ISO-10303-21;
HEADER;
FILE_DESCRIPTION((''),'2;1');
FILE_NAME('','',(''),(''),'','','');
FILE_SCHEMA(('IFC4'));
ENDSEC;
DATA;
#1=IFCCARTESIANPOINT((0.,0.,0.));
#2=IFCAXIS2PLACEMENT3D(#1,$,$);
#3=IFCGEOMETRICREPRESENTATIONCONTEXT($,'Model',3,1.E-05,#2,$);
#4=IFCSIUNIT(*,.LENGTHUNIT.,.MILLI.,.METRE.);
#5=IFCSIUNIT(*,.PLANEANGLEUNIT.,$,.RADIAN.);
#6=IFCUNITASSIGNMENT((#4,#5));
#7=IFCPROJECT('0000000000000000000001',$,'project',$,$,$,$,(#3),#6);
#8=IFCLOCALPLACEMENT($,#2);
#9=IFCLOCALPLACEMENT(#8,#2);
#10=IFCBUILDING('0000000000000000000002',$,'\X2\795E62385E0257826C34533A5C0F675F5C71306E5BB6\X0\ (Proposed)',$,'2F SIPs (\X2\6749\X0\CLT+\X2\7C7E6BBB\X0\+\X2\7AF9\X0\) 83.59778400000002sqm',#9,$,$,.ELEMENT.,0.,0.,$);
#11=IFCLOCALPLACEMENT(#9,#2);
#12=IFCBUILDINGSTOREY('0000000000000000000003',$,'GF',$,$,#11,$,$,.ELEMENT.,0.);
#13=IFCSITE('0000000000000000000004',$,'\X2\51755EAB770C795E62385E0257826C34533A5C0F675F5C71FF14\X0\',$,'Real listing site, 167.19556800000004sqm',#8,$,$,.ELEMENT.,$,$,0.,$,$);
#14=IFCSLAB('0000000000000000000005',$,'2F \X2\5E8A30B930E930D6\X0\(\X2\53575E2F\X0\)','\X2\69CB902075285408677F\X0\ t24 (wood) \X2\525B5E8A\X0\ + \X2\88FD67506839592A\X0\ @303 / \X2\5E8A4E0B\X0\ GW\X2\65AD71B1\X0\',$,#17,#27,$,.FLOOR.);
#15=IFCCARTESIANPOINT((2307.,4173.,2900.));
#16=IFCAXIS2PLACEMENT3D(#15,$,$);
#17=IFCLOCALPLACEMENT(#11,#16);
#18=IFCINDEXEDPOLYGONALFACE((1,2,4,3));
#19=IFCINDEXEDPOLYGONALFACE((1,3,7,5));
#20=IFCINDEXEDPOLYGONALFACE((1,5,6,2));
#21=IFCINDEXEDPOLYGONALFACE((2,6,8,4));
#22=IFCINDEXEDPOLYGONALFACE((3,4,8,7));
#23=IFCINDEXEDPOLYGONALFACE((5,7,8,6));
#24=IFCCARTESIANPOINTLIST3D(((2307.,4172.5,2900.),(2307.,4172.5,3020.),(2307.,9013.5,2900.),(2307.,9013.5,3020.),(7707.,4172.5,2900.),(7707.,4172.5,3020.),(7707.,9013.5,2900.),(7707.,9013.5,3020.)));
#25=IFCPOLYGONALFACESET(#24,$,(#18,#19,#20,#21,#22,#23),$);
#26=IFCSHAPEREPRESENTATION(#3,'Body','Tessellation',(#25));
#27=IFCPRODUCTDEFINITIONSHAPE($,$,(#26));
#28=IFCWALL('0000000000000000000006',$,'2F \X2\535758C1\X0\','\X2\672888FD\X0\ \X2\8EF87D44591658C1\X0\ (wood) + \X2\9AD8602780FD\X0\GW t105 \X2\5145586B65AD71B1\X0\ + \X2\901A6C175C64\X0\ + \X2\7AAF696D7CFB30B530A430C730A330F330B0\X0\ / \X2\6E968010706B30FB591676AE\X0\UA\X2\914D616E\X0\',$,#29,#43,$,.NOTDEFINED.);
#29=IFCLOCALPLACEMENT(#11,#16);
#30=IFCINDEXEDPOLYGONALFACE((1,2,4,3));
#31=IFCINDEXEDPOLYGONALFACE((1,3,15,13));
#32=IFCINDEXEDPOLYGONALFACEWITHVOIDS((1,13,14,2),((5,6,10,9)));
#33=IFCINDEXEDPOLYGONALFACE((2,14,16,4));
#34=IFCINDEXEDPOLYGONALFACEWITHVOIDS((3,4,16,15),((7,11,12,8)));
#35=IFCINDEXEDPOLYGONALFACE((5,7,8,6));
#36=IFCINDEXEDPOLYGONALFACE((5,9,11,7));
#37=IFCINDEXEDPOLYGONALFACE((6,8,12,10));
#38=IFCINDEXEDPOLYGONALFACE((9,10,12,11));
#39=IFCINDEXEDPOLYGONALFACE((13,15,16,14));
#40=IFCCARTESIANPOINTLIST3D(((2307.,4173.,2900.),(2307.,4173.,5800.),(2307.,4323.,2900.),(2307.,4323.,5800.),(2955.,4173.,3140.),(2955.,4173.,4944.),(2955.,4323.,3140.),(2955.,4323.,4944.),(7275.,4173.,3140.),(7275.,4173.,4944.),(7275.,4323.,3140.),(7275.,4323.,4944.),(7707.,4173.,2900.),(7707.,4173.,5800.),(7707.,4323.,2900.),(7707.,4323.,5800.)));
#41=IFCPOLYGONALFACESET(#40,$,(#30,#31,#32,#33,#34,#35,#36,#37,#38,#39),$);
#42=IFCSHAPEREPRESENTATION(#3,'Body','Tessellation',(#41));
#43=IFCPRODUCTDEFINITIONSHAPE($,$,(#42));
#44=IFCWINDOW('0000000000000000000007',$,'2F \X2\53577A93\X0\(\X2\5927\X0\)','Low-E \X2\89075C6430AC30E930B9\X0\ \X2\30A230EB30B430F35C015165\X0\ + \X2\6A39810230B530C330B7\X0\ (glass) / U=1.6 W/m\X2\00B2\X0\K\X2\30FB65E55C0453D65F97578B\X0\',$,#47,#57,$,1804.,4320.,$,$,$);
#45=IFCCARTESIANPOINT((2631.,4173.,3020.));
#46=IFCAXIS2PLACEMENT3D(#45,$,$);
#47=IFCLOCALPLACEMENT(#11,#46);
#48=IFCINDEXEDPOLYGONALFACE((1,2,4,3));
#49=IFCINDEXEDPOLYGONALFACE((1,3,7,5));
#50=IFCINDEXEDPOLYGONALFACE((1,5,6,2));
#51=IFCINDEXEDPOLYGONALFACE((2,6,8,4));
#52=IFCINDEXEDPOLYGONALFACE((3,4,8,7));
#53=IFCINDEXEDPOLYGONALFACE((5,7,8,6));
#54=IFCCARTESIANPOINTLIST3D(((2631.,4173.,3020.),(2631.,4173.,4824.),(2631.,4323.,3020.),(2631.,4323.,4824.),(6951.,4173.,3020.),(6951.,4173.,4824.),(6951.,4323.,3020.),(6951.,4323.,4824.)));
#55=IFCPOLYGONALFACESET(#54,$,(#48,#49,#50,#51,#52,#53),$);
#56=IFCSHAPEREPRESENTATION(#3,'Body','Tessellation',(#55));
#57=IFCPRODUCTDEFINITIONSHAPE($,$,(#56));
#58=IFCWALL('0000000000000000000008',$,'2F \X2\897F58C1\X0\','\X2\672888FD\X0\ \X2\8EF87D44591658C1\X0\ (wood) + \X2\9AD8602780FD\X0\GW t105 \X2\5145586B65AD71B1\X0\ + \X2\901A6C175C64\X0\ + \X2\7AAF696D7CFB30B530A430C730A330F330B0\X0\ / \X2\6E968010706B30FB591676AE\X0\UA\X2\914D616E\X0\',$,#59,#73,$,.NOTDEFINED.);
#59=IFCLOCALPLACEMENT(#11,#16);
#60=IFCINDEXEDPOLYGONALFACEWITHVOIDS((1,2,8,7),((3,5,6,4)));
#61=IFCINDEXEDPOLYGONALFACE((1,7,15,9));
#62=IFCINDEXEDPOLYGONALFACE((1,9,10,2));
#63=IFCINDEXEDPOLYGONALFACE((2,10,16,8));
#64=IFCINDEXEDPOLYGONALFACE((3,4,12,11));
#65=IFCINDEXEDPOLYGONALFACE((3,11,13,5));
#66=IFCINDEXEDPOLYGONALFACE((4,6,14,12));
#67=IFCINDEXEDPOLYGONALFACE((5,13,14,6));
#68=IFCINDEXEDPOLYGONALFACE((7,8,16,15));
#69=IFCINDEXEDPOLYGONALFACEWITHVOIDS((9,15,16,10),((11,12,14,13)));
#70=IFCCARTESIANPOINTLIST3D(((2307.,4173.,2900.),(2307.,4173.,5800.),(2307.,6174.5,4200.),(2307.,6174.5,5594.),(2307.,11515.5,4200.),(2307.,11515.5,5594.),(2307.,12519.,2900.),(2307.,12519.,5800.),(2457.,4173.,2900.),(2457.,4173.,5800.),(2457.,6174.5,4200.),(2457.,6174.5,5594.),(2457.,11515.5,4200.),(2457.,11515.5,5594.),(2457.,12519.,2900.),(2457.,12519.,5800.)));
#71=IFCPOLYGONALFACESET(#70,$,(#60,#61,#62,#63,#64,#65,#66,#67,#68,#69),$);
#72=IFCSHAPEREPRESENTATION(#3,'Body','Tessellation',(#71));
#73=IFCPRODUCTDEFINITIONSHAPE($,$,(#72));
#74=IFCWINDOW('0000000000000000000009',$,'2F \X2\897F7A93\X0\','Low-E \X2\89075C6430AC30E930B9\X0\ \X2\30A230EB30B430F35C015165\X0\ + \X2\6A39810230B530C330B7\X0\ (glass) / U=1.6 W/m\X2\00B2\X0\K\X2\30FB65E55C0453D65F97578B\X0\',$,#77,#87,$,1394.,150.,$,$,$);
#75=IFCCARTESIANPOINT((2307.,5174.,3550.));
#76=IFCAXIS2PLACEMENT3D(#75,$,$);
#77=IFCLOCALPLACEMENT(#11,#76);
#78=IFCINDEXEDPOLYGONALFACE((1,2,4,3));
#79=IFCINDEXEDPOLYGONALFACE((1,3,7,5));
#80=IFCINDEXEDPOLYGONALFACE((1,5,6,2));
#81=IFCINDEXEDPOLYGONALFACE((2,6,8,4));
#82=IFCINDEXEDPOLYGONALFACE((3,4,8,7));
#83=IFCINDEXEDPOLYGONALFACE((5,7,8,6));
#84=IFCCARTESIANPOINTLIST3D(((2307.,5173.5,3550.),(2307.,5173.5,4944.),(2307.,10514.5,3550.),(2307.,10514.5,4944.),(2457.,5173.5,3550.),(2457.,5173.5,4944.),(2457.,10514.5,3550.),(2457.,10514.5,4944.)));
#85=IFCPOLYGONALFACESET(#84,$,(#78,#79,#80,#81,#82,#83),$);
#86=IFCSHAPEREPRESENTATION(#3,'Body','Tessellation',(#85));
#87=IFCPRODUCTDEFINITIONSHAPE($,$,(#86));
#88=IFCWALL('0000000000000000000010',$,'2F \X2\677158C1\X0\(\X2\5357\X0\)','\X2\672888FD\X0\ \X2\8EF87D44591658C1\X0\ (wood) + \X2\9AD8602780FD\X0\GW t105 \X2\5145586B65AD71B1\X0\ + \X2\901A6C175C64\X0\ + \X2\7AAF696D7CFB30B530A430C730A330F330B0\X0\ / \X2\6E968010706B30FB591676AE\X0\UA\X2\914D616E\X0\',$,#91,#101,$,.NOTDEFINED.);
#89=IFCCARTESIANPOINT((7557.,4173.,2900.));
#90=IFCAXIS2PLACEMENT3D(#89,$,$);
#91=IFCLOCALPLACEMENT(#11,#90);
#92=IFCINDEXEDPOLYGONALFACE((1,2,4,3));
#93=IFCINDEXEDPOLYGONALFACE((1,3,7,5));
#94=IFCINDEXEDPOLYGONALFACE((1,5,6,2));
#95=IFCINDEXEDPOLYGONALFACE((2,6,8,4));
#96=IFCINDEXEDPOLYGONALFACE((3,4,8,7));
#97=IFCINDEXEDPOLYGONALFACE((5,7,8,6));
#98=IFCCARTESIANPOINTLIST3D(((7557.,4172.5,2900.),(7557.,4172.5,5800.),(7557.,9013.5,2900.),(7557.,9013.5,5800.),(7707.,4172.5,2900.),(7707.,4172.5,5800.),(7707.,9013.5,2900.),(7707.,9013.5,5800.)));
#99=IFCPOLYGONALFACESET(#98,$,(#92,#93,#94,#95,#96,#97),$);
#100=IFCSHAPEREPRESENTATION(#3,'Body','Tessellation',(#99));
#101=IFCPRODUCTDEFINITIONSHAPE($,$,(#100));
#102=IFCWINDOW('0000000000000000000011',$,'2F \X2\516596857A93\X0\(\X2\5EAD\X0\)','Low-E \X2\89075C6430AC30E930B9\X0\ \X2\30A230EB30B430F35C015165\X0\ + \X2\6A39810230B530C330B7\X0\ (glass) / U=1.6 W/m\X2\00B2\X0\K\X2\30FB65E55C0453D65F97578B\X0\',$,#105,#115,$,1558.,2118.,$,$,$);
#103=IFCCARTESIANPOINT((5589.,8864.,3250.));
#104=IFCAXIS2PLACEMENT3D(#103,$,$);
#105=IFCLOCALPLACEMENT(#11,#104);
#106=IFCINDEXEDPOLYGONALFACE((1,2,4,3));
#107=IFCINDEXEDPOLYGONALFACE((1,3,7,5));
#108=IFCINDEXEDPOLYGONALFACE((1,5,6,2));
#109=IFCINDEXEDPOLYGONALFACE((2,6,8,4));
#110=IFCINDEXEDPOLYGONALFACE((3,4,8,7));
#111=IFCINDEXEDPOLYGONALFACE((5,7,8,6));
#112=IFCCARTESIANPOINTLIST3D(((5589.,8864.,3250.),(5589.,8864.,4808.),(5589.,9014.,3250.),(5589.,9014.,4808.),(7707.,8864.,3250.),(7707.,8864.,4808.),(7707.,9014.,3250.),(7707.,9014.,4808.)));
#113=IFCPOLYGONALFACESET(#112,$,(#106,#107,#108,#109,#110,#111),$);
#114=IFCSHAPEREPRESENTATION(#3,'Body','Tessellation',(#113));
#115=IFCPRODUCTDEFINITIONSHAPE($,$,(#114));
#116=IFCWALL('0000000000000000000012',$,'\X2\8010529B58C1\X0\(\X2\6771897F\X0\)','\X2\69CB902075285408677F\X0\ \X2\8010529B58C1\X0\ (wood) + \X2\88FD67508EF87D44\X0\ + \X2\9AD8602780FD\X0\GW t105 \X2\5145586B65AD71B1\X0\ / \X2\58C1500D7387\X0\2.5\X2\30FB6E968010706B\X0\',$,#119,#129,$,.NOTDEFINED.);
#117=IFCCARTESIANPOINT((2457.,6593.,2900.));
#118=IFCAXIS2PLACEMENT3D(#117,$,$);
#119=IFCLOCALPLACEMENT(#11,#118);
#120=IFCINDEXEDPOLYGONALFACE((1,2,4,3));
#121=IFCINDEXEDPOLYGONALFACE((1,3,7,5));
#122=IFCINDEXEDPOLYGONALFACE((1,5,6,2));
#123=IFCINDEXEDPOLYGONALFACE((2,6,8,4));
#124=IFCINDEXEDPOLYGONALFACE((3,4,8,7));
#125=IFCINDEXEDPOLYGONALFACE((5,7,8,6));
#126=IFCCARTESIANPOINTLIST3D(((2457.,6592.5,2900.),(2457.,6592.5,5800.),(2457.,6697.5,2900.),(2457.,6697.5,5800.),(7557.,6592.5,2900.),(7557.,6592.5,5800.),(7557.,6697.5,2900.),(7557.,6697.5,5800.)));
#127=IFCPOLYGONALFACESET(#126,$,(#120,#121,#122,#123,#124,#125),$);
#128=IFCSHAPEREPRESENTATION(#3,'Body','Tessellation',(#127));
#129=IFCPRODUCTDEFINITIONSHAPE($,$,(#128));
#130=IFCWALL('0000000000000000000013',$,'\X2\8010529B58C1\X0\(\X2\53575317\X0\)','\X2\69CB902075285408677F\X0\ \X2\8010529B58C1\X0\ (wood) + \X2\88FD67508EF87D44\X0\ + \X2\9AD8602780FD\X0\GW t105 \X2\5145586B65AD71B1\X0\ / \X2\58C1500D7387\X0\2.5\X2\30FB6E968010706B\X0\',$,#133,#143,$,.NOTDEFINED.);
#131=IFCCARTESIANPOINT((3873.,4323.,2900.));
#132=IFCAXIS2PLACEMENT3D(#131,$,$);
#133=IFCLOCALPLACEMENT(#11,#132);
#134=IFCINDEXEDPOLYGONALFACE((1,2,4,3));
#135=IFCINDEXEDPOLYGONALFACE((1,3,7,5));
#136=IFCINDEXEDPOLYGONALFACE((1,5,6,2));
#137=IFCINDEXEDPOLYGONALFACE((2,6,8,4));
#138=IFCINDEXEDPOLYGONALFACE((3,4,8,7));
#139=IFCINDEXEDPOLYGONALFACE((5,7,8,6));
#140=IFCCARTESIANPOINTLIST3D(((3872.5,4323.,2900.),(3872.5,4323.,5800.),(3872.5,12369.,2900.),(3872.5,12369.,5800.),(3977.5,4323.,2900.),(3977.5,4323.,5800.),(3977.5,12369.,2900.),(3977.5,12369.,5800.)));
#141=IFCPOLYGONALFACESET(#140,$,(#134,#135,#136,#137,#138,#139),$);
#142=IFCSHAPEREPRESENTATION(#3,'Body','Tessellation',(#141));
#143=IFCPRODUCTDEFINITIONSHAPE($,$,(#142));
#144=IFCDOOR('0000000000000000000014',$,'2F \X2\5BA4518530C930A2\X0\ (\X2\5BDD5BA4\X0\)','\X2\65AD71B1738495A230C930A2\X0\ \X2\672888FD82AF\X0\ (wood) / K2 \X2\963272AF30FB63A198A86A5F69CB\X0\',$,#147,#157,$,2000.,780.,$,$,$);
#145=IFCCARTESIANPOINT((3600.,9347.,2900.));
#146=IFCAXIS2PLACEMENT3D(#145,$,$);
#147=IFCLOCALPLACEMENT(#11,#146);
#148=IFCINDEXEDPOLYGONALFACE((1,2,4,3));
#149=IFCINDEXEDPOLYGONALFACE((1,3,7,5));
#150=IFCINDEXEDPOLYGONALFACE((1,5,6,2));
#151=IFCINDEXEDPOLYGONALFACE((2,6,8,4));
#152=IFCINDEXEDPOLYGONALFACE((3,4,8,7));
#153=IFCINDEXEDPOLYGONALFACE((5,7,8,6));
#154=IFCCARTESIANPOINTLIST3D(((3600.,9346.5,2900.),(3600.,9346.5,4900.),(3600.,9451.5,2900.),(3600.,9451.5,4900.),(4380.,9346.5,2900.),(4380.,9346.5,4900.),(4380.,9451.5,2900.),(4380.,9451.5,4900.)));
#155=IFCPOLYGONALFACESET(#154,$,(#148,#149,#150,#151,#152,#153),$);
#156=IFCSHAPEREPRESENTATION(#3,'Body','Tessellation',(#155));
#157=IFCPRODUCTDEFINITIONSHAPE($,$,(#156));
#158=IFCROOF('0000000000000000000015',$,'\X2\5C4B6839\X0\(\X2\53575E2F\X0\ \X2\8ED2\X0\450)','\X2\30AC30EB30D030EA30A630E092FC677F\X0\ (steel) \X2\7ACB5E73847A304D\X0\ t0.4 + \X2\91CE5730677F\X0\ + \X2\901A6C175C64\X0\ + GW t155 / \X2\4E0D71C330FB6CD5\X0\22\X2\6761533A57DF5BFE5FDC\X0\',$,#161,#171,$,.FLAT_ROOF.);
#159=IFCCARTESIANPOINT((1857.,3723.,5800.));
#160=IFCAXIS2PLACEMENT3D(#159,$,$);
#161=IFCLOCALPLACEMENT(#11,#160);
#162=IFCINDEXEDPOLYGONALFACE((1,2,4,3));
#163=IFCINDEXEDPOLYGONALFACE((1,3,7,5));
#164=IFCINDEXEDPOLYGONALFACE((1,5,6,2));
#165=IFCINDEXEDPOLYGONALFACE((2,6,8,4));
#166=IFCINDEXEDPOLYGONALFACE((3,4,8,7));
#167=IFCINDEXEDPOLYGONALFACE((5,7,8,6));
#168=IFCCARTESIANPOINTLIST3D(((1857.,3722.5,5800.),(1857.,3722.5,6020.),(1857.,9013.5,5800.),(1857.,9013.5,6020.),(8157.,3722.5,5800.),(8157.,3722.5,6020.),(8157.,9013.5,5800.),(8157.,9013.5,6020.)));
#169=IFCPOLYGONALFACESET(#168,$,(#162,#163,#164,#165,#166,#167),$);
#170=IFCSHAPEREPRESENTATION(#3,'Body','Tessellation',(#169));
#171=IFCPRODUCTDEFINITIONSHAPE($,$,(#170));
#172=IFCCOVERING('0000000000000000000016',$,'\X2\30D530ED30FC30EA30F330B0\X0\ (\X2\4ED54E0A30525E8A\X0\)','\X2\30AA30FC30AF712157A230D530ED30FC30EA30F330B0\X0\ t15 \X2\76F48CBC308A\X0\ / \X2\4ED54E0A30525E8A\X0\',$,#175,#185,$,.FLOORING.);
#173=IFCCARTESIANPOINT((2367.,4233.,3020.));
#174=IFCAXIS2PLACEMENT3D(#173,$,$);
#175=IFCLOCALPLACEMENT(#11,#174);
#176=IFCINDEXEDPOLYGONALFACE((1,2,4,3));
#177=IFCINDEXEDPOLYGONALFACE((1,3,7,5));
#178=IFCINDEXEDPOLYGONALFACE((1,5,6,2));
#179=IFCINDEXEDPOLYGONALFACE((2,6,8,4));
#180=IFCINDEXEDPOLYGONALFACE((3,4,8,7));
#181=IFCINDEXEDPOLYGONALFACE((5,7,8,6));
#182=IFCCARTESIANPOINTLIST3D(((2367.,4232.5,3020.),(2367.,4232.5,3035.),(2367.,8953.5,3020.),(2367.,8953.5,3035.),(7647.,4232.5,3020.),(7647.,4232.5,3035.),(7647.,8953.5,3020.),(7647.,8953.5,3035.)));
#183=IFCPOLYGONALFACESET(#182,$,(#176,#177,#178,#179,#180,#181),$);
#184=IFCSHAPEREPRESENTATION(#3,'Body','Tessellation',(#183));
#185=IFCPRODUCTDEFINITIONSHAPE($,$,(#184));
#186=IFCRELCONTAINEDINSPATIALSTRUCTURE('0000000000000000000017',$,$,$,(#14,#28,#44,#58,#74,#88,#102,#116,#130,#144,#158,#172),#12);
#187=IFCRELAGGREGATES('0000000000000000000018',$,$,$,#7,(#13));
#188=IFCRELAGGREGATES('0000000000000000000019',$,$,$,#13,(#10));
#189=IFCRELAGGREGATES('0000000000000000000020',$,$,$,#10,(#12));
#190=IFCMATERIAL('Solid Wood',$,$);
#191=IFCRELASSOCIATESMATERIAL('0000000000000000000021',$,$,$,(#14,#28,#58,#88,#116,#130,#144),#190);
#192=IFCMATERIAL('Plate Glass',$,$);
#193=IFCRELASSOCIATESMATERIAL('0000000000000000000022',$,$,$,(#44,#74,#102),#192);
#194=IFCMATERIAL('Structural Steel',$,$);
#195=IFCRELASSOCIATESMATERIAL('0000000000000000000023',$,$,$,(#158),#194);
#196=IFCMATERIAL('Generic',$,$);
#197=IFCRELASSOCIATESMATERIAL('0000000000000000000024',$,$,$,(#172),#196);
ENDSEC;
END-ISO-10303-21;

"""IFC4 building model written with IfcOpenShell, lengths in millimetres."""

from ifc_helpers import new_model, si_unit, frame, frame_2d, origin, place, context, project, spatial, rectangle, extrude, material, element, fill, save


model = new_model("IFC4")

# Units and contexts
model_context = context("Model", 3, precision=1e-05, world=origin())
ifc_project = project(units=[si_unit("LENGTHUNIT", "METRE", prefix="MILLI"), si_unit("PLANEANGLEUNIT", "RADIAN")], contexts=[model_context])

# Site, building, storey
site_placement = place(None, origin())
site = spatial("IfcSite", under=ifc_project, at=site_placement, Name="兵庫県神戸市垂水区小束山４", ObjectType="Real listing site, 167.19556800000004sqm", CompositionType="ELEMENT", RefElevation=0.0)
building_placement = place(site_placement, origin())
building = spatial("IfcBuilding", under=site, at=building_placement, Name="神戸市垂水区小束山の家 (Proposed)", ObjectType="2F SIPs (杉CLT+籾殻+竹) 83.59778400000002sqm", CompositionType="ELEMENT", ElevationOfRefHeight=0.0, ElevationOfTerrain=0.0)
storey_placement = place(building_placement, origin())
storey = spatial("IfcBuildingStorey", under=building, at=storey_placement, Name="GF", CompositionType="ELEMENT", Elevation=0.0)

# Slab
ifc_material_1 = material(Name="Solid Wood")
slab_placement = place(storey_placement, frame((2307.0, 4173.0, 2900.0)))
element("IfcSlab", 1, at=slab_placement, inside=storey, material=ifc_material_1, Name="2F 床スラブ(南帯)", Description="構造用合板 t24 (wood) 剛床 + 製材根太 @303 / 床下 GW断熱", PredefinedType="FLOOR", context=model_context, shape_type="SweptSolid", body=[
    extrude(rectangle(XDim=5400.0, YDim=4841.0, at=frame_2d((2700.0, 2420.0))), frame((2307.0, 4173.0, 2900.0)), (0.0, 0.0, 1.0), 120.0),
])

# Walls, openings, windows
wall_1_placement = place(storey_placement, frame((2307.0, 4173.0, 2900.0)))
wall_1 = element("IfcWall", 2, at=wall_1_placement, inside=storey, material=ifc_material_1, Name="2F 南壁", Description="木製 軸組外壁 (wood) + 高性能GW t105 充填断熱 + 通気層 + 窯業系サイディング / 準耐火・外皮UA配慮", PredefinedType="NOTDEFINED", context=model_context, shape_type="SweptSolid", body=[
    extrude(rectangle(XDim=5400.0, YDim=150.0, at=frame_2d((2700.0, 75.0))), frame((2307.0, 4173.0, 2900.0)), (0.0, 0.0, 1.0), 2900.0),
])
opening_1_placement = place(storey_placement, frame((2631.0, 4173.0, 3020.0)))
opening_1 = element("IfcOpeningElement", 3, at=opening_1_placement, cuts=wall_1, PredefinedType="NOTDEFINED", context=model_context, shape_type="SweptSolid", body=[
    extrude(rectangle(XDim=4320.0, YDim=150.0, at=frame_2d((2160.0, 75.0))), frame((2631.0, 4173.0, 3020.0)), (0.0, 0.0, 1.0), 1804.0),
])
ifc_material_2 = material(Name="Plate Glass")
window_1_placement = place(storey_placement, frame((2631.0, 4173.0, 3020.0)))
window_1 = element("IfcWindow", 4, at=window_1_placement, inside=storey, material=ifc_material_2, Name="2F 南窓(大)", Description="Low-E 複層ガラス アルゴン封入 + 樹脂サッシ (glass) / U=1.6 W/m²K・日射取得型", OverallHeight=1804.0, OverallWidth=4320.0, context=model_context, shape_type="SweptSolid", body=[
    extrude(rectangle(XDim=4320.0, YDim=150.0, at=frame_2d((2160.0, 75.0))), frame((2631.0, 4173.0, 3020.0)), (0.0, 0.0, 1.0), 1804.0),
])
fill(opening_1, window_1)
wall_2_placement = place(storey_placement, frame((2307.0, 4173.0, 2900.0)))
wall_2 = element("IfcWall", 5, at=wall_2_placement, inside=storey, material=ifc_material_1, Name="2F 西壁", Description="木製 軸組外壁 (wood) + 高性能GW t105 充填断熱 + 通気層 + 窯業系サイディング / 準耐火・外皮UA配慮", PredefinedType="NOTDEFINED", context=model_context, shape_type="SweptSolid", body=[
    extrude(rectangle(XDim=150.0, YDim=8346.0, at=frame_2d((75.0, 4173.0))), frame((2307.0, 4173.0, 2900.0)), (0.0, 0.0, 1.0), 2900.0),
])
opening_2_placement = place(storey_placement, frame((2307.0, 5174.0, 3550.0)))
opening_2 = element("IfcOpeningElement", 6, at=opening_2_placement, cuts=wall_2, PredefinedType="NOTDEFINED", context=model_context, shape_type="SweptSolid", body=[
    extrude(rectangle(XDim=150.0, YDim=5341.0, at=frame_2d((75.0, 2670.0))), frame((2307.0, 5174.0, 3550.0)), (0.0, 0.0, 1.0), 1394.0),
])
window_2_placement = place(storey_placement, frame((2307.0, 5174.0, 3550.0)))
window_2 = element("IfcWindow", 7, at=window_2_placement, inside=storey, material=ifc_material_2, Name="2F 西窓", Description="Low-E 複層ガラス アルゴン封入 + 樹脂サッシ (glass) / U=1.6 W/m²K・日射取得型", OverallHeight=1394.0, OverallWidth=150.0, context=model_context, shape_type="SweptSolid", body=[
    extrude(rectangle(XDim=150.0, YDim=5341.0, at=frame_2d((75.0, 2670.0))), frame((2307.0, 5174.0, 3550.0)), (0.0, 0.0, 1.0), 1394.0),
])
fill(opening_2, window_2)
wall_3_placement = place(storey_placement, frame((7557.0, 4173.0, 2900.0)))
wall_3 = element("IfcWall", 8, at=wall_3_placement, inside=storey, material=ifc_material_1, Name="2F 東壁(南)", Description="木製 軸組外壁 (wood) + 高性能GW t105 充填断熱 + 通気層 + 窯業系サイディング / 準耐火・外皮UA配慮", PredefinedType="NOTDEFINED", context=model_context, shape_type="SweptSolid", body=[
    extrude(rectangle(XDim=150.0, YDim=4841.0, at=frame_2d((75.0, 2420.0))), frame((7557.0, 4173.0, 2900.0)), (0.0, 0.0, 1.0), 2900.0),
])
opening_3_placement = place(storey_placement, frame((5589.0, 8864.0, 3250.0)))
opening_3 = element("IfcOpeningElement", 9, at=opening_3_placement, cuts=wall_3, PredefinedType="NOTDEFINED", context=model_context, shape_type="SweptSolid", body=[
    extrude(rectangle(XDim=2118.0, YDim=150.0, at=frame_2d((1059.0, 75.0))), frame((5589.0, 8864.0, 3250.0)), (0.0, 0.0, 1.0), 1558.0),
])
window_3_placement = place(storey_placement, frame((5589.0, 8864.0, 3250.0)))
window_3 = element("IfcWindow", 10, at=window_3_placement, inside=storey, material=ifc_material_2, Name="2F 入隅窓(庭)", Description="Low-E 複層ガラス アルゴン封入 + 樹脂サッシ (glass) / U=1.6 W/m²K・日射取得型", OverallHeight=1558.0, OverallWidth=2118.0, context=model_context, shape_type="SweptSolid", body=[
    extrude(rectangle(XDim=2118.0, YDim=150.0, at=frame_2d((1059.0, 75.0))), frame((5589.0, 8864.0, 3250.0)), (0.0, 0.0, 1.0), 1558.0),
])
fill(opening_3, window_3)

# Wall
wall_4_placement = place(storey_placement, frame((2457.0, 6593.0, 2900.0)))
element("IfcWall", 11, at=wall_4_placement, inside=storey, material=ifc_material_1, Name="耐力壁(東西)", Description="構造用合板 耐力壁 (wood) + 製材軸組 + 高性能GW t105 充填断熱 / 壁倍率2.5・準耐火", PredefinedType="NOTDEFINED", context=model_context, shape_type="SweptSolid", body=[
    extrude(rectangle(XDim=5100.0, YDim=105.0, at=frame_2d((2550.0, 52.0))), frame((2457.0, 6593.0, 2900.0)), (0.0, 0.0, 1.0), 2900.0),
])

# Wall, opening, door
wall_5_placement = place(storey_placement, frame((3873.0, 4323.0, 2900.0)))
wall_5 = element("IfcWall", 12, at=wall_5_placement, inside=storey, material=ifc_material_1, Name="耐力壁(南北)", Description="構造用合板 耐力壁 (wood) + 製材軸組 + 高性能GW t105 充填断熱 / 壁倍率2.5・準耐火", PredefinedType="NOTDEFINED", context=model_context, shape_type="SweptSolid", body=[
    extrude(rectangle(XDim=105.0, YDim=8046.0, at=frame_2d((52.0, 4023.0))), frame((3873.0, 4323.0, 2900.0)), (0.0, 0.0, 1.0), 2900.0),
])
opening_4_placement = place(storey_placement, frame((3600.0, 9347.0, 2900.0)))
opening_4 = element("IfcOpeningElement", 13, at=opening_4_placement, cuts=wall_5, PredefinedType="NOTDEFINED", context=model_context, shape_type="SweptSolid", body=[
    extrude(rectangle(XDim=780.0, YDim=105.0, at=frame_2d((390.0, 52.0))), frame((3600.0, 9347.0, 2900.0)), (0.0, 0.0, 1.0), 2000.0),
])
door_placement = place(storey_placement, frame((3600.0, 9347.0, 2900.0)))
door = element("IfcDoor", 14, at=door_placement, inside=storey, material=ifc_material_1, Name="2F 室内ドア (寝室)", Description="断熱玄関ドア 木製芯 (wood) / K2 防犯・採風機構", OverallHeight=2000.0, OverallWidth=780.0, context=model_context, shape_type="SweptSolid", body=[
    extrude(rectangle(XDim=780.0, YDim=105.0, at=frame_2d((390.0, 52.0))), frame((3600.0, 9347.0, 2900.0)), (0.0, 0.0, 1.0), 2000.0),
])
fill(opening_4, door)

# Roof
ifc_material_3 = material(Name="Structural Steel")
for number, where, name in (
    (15, (1857.0, 3723.0, 5800.0), "屋根(南帯 軒450)"),
):
    element("IfcRoof", number, at=place(storey_placement, frame(where)), inside=storey, material=ifc_material_3, Name=name, Description="ガルバリウム鋼板 (steel) 立平葺き t0.4 + 野地板 + 通気層 + GW t155 / 不燃・法22条区域対応", PredefinedType="FLAT_ROOF", context=model_context, shape_type="SweptSolid", body=[
        extrude(rectangle(XDim=6300.0, YDim=5291.0, at=frame_2d((3150.0, 2645.0))), frame((1857.0, 3723.0, 5800.0)), (0.0, 0.0, 1.0), 220.0),
    ])

# Covering
ifc_material_4 = material(Name="Generic")
covering_placement = place(storey_placement, frame((2367.0, 4233.0, 3020.0)))
element("IfcCovering", 16, at=covering_placement, inside=storey, material=ifc_material_4, Name="フローリング (仕上げ床)", Description="オーク無垢フローリング t15 直貼り / 仕上げ床", PredefinedType="FLOORING", context=model_context, shape_type="SweptSolid", body=[
    extrude(rectangle(XDim=5280.0, YDim=4721.0, at=frame_2d((2640.0, 2360.0))), frame((2367.0, 4233.0, 3020.0)), (0.0, 0.0, 1.0), 15.0),
])

save(model, "model.ifc")
